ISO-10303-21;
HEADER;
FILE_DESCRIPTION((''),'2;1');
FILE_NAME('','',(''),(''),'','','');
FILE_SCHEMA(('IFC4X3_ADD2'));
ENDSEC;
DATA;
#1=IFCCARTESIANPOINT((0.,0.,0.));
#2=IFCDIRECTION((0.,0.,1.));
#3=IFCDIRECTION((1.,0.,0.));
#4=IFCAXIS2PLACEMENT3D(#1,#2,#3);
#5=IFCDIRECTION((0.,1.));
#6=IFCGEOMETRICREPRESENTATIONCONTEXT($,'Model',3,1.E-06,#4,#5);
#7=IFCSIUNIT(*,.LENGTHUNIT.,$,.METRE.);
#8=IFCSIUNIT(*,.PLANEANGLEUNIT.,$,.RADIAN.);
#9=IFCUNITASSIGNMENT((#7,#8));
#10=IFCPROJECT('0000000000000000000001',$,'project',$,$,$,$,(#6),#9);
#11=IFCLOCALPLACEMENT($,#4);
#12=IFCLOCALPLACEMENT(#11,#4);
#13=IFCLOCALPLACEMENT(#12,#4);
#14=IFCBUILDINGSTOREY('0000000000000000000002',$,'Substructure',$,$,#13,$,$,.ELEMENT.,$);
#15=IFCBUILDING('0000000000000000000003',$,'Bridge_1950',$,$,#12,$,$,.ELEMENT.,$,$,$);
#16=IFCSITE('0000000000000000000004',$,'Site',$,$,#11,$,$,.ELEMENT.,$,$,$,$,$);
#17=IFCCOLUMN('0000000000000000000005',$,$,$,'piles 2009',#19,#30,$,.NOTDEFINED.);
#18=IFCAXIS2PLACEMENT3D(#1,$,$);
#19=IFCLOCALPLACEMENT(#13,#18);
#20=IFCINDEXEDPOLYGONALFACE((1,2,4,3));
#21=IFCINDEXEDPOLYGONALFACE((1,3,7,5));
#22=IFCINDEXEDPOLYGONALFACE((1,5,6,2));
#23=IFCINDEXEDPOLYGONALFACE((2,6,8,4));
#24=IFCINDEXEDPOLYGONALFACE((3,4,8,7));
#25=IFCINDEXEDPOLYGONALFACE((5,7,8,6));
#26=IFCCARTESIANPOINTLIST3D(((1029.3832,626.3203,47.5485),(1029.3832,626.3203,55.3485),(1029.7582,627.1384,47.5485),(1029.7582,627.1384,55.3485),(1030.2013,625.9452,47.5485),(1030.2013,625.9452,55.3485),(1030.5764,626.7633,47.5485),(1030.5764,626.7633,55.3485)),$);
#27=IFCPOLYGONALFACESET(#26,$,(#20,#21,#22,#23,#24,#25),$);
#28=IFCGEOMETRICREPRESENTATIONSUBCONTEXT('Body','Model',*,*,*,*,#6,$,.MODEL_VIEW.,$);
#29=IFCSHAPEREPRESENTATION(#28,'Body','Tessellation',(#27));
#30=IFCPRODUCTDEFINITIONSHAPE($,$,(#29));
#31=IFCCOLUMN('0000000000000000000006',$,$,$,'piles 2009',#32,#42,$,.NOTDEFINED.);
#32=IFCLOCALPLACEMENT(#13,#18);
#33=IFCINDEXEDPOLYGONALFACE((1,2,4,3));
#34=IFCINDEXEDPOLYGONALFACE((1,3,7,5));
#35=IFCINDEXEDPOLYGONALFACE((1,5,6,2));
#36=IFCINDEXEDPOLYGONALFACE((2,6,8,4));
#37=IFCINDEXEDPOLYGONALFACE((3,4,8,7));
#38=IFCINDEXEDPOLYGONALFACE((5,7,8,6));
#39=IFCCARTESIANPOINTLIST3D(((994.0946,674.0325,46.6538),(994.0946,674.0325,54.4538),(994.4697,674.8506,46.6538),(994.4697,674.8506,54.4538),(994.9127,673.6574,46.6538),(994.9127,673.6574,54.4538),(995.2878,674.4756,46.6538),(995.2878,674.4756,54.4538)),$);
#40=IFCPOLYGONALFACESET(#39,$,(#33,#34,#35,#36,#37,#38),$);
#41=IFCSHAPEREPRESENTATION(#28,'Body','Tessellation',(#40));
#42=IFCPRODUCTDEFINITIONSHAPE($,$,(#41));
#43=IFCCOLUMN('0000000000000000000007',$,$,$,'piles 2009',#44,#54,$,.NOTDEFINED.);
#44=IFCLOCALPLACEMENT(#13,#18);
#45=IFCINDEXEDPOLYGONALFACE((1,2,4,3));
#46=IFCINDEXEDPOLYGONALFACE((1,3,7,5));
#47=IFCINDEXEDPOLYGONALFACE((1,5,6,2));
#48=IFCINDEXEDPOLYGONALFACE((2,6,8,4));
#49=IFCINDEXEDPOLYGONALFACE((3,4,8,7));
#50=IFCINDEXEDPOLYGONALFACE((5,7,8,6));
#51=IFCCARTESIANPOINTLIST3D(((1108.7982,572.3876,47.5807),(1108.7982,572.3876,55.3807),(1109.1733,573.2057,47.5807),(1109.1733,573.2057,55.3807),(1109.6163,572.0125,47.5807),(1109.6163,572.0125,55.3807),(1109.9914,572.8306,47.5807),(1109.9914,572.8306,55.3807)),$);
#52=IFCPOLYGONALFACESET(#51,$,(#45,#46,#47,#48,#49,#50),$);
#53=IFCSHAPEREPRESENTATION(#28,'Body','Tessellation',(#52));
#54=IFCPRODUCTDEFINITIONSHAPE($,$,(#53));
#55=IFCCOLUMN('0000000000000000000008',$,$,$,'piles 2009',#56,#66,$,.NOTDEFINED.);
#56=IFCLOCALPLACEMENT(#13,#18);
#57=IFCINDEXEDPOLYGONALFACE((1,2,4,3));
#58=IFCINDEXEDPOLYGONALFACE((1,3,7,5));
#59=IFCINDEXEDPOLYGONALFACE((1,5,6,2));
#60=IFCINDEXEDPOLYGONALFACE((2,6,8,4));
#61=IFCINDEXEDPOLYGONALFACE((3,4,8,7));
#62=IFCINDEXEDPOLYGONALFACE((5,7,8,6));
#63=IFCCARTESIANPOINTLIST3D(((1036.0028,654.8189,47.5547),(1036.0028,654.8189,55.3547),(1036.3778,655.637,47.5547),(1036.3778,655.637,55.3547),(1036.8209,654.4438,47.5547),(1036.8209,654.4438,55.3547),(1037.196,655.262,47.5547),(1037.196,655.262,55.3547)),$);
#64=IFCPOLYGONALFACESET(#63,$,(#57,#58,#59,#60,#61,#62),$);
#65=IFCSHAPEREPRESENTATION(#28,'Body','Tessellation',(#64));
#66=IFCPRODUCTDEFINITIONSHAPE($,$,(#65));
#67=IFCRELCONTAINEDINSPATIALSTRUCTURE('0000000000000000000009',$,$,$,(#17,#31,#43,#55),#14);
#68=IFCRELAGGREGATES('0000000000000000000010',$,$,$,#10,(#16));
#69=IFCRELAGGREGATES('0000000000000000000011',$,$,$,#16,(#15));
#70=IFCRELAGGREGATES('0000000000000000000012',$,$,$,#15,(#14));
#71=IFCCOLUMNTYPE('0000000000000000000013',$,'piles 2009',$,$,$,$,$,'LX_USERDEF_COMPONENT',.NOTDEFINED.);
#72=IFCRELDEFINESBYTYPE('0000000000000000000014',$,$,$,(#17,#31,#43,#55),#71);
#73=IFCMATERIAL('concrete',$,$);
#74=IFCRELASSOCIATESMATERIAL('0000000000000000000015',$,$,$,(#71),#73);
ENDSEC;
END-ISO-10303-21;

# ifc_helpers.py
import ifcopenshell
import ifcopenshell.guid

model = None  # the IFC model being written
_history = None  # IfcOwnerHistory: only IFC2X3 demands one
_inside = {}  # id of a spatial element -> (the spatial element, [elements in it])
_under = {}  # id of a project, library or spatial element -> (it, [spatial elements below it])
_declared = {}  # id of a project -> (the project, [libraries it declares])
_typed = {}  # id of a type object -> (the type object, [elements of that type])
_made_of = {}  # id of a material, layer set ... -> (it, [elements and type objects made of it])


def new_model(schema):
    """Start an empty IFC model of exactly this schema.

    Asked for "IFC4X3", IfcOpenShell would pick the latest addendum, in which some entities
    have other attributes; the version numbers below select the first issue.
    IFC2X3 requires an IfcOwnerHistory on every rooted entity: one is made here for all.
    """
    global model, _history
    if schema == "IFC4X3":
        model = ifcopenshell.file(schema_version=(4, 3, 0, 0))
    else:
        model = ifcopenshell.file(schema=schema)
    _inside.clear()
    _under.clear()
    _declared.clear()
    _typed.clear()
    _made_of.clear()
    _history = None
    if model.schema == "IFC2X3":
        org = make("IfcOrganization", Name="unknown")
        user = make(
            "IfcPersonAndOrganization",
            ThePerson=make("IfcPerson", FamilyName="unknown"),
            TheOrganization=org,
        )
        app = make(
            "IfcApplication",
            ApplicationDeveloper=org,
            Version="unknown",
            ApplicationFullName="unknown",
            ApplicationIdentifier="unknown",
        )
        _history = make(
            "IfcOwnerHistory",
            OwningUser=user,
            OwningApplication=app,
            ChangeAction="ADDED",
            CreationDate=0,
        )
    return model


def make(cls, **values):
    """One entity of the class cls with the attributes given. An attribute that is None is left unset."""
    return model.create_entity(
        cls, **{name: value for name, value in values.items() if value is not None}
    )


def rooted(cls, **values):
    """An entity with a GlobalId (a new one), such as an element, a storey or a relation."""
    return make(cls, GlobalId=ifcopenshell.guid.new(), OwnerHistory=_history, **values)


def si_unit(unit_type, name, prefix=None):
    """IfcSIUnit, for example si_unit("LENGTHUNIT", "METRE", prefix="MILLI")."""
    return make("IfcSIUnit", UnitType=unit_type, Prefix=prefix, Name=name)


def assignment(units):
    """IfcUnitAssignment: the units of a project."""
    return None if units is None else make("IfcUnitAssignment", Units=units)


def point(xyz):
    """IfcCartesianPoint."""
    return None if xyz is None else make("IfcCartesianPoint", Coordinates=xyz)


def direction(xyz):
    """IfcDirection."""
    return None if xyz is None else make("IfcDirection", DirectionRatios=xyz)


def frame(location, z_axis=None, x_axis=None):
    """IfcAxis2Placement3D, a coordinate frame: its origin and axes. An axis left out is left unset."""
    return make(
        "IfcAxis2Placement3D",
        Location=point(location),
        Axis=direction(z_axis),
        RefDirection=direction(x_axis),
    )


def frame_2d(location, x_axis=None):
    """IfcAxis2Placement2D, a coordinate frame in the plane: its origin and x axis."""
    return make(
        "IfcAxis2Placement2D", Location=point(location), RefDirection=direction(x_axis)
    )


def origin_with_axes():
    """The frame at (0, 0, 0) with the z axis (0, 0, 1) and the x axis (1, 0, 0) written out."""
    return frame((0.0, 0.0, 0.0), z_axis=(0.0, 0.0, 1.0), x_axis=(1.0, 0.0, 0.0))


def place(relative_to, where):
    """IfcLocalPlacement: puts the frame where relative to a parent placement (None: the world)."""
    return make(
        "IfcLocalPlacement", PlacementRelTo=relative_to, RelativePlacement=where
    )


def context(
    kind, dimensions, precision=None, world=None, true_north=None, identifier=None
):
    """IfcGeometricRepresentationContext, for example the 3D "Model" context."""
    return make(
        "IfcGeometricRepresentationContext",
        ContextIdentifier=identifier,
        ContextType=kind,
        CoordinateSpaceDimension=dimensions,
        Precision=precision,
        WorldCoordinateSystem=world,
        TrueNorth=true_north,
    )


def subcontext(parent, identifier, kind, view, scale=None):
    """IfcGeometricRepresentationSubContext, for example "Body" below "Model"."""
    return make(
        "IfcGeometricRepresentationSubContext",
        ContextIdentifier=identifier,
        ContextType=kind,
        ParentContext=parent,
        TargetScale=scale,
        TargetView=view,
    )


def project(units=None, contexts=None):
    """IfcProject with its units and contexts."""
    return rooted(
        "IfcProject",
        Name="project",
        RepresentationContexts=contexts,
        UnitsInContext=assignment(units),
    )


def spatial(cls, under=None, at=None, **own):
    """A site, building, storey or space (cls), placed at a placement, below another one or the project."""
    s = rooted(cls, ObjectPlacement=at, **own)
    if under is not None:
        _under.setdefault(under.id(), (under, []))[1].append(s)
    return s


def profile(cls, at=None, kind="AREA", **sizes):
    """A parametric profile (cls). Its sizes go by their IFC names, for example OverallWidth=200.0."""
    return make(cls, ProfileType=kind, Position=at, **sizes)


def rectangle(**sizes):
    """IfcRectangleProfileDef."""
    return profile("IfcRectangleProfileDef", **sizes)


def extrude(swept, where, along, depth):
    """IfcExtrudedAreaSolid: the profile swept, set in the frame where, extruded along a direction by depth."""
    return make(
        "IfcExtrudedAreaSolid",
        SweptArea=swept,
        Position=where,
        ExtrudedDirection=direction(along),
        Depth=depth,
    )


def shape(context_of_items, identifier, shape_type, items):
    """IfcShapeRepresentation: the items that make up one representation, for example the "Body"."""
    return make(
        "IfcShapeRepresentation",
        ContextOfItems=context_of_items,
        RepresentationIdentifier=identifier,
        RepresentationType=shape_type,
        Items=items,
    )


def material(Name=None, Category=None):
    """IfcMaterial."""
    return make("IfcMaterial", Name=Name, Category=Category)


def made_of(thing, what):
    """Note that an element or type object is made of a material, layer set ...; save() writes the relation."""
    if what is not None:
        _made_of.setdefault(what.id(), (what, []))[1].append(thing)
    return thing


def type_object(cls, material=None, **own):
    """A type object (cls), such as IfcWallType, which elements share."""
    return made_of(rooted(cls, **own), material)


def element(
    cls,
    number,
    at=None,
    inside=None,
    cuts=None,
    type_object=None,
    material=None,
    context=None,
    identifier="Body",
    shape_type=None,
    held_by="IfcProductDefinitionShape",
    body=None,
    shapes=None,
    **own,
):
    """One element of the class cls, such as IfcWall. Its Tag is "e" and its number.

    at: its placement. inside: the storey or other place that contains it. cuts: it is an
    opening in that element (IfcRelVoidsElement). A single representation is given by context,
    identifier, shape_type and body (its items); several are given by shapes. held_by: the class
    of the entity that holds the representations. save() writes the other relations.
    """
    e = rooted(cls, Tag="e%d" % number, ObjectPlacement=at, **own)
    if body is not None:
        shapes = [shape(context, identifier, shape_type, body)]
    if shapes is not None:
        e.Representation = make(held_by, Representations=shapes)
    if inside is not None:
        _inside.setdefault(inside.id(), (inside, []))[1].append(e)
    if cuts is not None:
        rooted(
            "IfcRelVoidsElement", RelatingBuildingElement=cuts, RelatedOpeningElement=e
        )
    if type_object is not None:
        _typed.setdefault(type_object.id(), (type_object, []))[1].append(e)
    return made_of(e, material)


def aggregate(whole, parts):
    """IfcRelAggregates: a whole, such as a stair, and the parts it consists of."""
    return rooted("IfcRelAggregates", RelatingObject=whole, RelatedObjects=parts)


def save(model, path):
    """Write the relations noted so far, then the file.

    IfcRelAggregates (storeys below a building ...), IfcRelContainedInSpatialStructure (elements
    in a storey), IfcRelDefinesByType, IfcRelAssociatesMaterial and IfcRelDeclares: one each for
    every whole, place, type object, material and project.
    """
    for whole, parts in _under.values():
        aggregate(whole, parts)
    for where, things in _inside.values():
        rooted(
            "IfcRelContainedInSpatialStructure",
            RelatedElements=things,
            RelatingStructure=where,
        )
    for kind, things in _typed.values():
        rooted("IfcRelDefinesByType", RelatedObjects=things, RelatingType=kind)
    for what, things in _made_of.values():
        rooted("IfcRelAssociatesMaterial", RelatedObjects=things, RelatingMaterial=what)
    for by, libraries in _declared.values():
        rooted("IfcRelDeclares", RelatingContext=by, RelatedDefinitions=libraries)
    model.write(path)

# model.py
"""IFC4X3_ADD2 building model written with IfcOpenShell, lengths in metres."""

from ifc_helpers import new_model, si_unit, direction, frame, frame_2d, origin_with_axes, place, context, subcontext, project, spatial, rectangle, extrude, material, type_object, element, save


model = new_model("IFC4X3_ADD2")

# Units and contexts
model_context = context("Model", 3, precision=1e-06, world=origin_with_axes(), true_north=direction((0.0, 1.0)))
body_context = subcontext(model_context, "Body", "Model", "MODEL_VIEW")
ifc_project = project(units=[si_unit("LENGTHUNIT", "METRE"), si_unit("PLANEANGLEUNIT", "RADIAN")], contexts=[model_context])

# Site, building, storey
site_placement = place(None, origin_with_axes())
site = spatial("IfcSite", under=ifc_project, at=site_placement, Name="Site", CompositionType="ELEMENT")
building_placement = place(site_placement, origin_with_axes())
building = spatial("IfcBuilding", under=site, at=building_placement, Name="Bridge_1950", CompositionType="ELEMENT")
storey_placement = place(building_placement, origin_with_axes())
storey = spatial("IfcBuildingStorey", under=building, at=storey_placement, Name="Substructure", CompositionType="ELEMENT")

# Columns
ifc_material = material(Name="concrete")
column_type = type_object("IfcColumnType", Name="piles 2009", ElementType="LX_USERDEF_COMPONENT", PredefinedType="NOTDEFINED", material=ifc_material)
for number, where, z_axis, x_axis in (
    (1, (1030.2013, 625.9452, 47.5485), (0.0, 0.0, 1.0), (0.416757, 0.909018, 0.0)),
    (2, (994.9127, 673.6574, 46.6538), (0.0, 0.0, 1.0), (0.416757, 0.909018, 0.0)),
    (3, (1109.6163, 572.0125, 47.5807), (0.0, 0.0, 1.0), (0.416757, 0.909018, 0.0)),
    (4, (1036.8209, 654.4438, 47.5547), (0.0, 0.0, 1.0), (0.416757, 0.909018, 0.0)),
):
    element("IfcColumn", number, at=place(storey_placement, frame(where, z_axis=z_axis, x_axis=x_axis)), inside=storey, type_object=column_type, ObjectType="piles 2009", PredefinedType="NOTDEFINED", context=body_context, shape_type="SweptSolid", body=[
        extrude(rectangle(XDim=0.9, YDim=0.9, at=frame_2d((0.45, 0.45), x_axis=(1.0, 0.0))), origin_with_axes(), (0.0, 0.0, 1.0), 7.8),
    ])

save(model, "model.ifc")
